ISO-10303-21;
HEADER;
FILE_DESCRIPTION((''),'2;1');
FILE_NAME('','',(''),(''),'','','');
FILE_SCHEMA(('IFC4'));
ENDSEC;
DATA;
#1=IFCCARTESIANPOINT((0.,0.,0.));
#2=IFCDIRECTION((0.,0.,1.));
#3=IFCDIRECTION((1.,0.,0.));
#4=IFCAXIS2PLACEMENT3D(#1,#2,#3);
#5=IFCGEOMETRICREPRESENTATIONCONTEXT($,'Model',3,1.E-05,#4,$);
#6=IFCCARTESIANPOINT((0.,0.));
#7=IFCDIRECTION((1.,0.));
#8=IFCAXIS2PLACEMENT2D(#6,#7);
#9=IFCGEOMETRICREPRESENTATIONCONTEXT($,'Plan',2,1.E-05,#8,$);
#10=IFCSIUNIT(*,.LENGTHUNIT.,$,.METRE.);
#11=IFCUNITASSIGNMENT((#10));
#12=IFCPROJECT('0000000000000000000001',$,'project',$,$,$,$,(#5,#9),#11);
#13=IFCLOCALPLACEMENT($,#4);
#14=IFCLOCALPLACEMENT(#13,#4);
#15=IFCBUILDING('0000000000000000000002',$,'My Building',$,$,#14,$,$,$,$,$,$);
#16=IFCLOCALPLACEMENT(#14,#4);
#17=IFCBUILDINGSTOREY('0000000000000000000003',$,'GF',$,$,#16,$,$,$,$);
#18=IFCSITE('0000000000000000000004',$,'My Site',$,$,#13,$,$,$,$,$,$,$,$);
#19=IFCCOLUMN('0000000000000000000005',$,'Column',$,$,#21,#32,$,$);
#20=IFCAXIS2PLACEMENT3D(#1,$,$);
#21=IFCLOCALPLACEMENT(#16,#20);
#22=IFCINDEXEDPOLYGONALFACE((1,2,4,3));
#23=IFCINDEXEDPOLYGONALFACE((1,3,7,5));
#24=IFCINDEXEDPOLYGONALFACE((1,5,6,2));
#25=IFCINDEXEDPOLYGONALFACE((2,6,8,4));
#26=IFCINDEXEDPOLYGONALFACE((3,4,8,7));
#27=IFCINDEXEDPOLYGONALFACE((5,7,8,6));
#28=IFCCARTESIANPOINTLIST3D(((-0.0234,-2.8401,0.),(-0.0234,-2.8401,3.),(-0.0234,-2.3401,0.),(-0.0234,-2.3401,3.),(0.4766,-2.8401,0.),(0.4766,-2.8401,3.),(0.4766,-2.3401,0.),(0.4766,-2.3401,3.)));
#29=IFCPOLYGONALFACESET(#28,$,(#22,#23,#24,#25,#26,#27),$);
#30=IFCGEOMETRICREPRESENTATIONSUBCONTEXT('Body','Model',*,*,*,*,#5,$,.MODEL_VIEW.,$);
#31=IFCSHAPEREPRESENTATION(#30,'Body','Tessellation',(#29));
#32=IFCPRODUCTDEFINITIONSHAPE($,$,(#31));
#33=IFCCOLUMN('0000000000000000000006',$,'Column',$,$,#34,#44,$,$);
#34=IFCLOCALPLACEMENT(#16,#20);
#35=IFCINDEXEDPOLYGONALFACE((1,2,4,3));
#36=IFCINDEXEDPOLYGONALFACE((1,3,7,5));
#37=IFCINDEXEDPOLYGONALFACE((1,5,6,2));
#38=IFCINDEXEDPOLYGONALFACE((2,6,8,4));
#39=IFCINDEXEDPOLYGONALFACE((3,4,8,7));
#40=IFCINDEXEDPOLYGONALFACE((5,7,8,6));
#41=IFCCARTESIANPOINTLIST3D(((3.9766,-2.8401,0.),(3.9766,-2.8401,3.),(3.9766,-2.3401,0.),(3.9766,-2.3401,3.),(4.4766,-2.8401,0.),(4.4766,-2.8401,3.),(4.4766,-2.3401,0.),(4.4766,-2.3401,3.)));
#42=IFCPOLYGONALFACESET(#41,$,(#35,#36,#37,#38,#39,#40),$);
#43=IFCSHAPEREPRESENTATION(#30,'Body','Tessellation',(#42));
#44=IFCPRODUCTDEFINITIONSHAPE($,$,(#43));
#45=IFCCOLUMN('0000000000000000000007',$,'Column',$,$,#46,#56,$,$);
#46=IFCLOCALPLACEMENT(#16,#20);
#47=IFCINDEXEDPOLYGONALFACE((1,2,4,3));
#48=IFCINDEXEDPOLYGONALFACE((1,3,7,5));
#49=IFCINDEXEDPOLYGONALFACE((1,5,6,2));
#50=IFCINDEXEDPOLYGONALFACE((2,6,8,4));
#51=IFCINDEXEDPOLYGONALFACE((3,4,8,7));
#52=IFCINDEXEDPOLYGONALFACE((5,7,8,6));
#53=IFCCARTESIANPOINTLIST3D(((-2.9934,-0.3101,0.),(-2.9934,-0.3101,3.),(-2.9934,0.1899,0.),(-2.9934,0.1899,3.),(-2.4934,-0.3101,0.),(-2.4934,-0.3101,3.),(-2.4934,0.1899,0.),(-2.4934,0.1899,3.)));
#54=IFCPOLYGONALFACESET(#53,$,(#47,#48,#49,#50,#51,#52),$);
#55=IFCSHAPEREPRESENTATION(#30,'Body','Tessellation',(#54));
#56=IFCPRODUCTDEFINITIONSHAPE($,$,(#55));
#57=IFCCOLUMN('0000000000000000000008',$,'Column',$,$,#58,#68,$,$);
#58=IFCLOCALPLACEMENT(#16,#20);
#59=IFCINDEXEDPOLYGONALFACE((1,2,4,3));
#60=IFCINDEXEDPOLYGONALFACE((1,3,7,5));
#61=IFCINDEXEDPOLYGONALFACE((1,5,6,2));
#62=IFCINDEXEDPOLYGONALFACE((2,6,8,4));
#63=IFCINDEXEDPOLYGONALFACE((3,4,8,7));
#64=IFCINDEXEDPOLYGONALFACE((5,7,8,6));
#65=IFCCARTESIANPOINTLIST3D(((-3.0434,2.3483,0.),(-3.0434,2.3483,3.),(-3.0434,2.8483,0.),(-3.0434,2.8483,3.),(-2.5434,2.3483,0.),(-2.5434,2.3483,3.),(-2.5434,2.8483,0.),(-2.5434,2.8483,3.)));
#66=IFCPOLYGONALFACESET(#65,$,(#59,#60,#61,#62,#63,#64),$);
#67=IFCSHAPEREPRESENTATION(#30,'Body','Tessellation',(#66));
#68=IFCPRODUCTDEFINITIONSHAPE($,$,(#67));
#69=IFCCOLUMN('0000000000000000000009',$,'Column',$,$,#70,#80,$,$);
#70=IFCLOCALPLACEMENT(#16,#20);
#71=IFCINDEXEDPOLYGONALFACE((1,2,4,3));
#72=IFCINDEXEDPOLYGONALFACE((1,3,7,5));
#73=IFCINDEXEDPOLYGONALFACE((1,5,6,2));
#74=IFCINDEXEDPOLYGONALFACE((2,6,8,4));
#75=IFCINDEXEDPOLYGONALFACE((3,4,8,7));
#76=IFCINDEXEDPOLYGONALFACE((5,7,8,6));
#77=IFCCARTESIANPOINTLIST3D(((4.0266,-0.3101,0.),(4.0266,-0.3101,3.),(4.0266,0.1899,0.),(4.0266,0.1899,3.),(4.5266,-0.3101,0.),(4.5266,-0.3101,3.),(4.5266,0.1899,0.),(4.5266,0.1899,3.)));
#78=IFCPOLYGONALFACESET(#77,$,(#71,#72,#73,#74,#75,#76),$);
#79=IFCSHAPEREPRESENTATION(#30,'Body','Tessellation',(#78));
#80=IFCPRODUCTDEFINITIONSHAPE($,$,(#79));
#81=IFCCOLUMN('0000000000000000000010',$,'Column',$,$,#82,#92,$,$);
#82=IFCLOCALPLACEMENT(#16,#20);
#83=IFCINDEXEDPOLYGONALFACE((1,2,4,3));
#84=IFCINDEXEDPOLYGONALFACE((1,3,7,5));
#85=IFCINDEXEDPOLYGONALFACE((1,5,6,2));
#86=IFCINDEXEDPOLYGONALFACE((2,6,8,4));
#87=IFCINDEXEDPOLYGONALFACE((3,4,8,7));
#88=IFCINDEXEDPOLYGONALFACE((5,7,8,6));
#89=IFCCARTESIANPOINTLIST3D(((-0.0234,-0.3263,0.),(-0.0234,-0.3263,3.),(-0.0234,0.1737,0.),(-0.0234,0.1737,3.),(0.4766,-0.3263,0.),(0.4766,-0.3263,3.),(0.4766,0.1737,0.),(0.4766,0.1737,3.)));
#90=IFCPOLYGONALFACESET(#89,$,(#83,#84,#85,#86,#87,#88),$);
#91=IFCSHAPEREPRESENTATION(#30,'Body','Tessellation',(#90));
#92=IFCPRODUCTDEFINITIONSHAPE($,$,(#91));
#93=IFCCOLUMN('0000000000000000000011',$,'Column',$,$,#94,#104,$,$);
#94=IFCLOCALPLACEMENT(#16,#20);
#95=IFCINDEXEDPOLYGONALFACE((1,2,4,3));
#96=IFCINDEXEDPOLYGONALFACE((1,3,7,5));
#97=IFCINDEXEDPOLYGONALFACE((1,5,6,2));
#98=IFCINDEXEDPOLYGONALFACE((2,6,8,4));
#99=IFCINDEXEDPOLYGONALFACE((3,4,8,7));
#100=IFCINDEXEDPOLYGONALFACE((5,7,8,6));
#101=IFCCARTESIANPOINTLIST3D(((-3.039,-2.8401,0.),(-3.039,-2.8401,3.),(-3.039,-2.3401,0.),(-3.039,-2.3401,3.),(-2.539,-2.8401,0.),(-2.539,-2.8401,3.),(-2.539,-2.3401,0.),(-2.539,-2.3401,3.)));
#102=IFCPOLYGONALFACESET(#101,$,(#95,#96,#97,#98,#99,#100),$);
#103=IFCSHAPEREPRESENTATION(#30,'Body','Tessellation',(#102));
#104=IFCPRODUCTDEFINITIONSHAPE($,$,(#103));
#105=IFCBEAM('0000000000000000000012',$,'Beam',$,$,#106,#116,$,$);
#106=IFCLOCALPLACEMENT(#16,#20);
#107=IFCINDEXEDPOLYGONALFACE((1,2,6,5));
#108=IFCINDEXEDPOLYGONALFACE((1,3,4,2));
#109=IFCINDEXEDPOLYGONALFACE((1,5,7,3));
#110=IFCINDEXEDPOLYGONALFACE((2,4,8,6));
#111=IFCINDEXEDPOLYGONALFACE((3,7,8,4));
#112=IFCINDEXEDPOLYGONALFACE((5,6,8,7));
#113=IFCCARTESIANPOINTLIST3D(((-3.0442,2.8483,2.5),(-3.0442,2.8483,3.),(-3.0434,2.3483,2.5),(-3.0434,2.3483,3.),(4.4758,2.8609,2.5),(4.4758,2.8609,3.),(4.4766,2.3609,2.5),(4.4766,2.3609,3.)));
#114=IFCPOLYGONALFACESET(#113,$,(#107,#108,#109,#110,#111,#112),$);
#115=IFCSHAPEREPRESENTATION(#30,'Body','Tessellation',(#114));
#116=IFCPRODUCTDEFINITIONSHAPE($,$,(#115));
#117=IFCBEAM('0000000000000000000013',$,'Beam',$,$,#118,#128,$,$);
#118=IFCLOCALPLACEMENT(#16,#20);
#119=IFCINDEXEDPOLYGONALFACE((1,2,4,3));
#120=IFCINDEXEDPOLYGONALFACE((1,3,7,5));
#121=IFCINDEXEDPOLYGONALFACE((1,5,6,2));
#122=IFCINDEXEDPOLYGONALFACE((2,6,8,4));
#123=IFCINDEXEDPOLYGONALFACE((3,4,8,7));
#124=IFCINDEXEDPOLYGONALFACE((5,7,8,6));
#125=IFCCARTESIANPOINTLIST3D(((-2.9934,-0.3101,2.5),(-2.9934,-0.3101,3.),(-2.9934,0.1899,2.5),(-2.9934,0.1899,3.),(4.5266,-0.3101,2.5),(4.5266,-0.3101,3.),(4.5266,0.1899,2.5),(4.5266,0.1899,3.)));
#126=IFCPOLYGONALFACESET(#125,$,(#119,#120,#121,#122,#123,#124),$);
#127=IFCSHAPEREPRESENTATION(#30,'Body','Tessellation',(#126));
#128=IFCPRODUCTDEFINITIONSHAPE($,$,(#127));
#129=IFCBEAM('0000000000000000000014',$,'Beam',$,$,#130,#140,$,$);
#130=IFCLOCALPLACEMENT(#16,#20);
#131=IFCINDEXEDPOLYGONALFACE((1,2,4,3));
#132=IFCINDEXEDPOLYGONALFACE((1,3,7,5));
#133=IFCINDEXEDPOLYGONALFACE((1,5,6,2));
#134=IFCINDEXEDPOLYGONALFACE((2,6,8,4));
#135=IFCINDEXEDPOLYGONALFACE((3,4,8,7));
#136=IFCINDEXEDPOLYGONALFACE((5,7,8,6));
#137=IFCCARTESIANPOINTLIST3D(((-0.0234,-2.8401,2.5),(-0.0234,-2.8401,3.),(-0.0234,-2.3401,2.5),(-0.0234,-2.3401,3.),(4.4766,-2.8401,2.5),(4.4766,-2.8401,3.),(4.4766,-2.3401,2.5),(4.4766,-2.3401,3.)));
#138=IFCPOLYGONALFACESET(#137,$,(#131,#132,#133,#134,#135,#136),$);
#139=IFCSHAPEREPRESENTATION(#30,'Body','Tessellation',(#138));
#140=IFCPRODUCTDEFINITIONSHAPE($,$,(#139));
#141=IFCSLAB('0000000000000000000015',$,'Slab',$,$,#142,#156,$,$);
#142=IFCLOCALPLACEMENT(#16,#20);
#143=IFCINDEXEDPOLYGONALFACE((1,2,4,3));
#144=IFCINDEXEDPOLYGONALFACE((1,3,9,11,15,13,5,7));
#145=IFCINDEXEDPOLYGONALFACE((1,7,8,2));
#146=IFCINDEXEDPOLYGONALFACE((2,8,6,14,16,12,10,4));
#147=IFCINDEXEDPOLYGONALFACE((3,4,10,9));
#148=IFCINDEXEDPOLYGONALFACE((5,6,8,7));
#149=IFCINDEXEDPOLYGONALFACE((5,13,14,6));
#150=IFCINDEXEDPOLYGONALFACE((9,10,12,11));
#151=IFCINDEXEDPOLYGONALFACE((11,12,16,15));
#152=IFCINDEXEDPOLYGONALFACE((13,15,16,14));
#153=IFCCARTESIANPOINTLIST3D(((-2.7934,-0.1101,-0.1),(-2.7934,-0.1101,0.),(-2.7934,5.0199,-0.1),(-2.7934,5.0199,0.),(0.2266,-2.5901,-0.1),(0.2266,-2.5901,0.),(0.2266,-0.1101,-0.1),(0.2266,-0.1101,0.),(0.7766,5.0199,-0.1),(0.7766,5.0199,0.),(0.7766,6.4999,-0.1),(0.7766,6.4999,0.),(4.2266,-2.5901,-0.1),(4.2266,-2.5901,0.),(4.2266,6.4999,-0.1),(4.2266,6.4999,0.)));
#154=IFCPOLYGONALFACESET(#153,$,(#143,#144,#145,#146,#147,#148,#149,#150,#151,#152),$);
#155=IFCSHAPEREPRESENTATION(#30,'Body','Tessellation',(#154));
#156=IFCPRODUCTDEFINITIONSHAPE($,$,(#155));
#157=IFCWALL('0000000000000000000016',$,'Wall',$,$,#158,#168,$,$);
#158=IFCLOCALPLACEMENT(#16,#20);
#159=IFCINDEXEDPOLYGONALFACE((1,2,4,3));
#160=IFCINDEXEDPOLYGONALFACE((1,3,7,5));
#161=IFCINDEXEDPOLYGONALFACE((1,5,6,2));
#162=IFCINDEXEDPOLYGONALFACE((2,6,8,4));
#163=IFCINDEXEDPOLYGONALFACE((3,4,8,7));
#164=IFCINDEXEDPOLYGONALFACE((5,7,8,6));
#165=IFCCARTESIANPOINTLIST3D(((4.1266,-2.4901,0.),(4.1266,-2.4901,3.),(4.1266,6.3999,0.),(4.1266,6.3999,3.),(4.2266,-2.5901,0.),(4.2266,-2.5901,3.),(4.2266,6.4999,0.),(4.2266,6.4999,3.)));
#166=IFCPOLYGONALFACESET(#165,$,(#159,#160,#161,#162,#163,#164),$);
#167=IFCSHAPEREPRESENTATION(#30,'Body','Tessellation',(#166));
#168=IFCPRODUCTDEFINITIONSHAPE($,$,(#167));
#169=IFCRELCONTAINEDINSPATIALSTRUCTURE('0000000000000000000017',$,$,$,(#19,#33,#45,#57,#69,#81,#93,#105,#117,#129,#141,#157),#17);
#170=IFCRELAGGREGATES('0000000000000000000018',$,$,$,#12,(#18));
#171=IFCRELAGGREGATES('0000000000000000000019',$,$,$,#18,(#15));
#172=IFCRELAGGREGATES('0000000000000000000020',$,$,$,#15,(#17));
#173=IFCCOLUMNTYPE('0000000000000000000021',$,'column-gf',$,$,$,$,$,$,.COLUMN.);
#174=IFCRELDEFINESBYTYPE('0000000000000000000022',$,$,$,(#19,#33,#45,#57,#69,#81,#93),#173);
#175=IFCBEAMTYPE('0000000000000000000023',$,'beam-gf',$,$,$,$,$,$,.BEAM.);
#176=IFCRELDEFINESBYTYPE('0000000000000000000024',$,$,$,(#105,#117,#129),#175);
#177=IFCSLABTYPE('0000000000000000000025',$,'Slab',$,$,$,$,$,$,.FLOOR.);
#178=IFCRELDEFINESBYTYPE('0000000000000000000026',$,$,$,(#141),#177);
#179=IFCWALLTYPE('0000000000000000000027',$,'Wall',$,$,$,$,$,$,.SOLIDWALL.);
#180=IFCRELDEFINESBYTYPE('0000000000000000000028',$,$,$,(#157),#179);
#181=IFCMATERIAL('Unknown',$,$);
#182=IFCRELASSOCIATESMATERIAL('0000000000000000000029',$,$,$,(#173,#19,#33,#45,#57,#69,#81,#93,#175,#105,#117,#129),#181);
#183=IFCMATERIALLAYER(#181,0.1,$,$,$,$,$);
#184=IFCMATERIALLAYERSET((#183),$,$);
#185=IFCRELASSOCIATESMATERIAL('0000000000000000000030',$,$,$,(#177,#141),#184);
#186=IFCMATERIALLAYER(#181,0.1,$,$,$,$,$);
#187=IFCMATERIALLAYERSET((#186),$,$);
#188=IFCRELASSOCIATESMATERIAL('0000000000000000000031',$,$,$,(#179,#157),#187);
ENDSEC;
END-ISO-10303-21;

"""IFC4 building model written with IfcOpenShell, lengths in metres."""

from ifc_helpers import new_model, si_unit, frame, origin_with_axes, origin_2d_with_axis, place, context, subcontext, project, spatial, line, indexed_curve, rectangle, outline, extrude, material, layer, layer_set, layer_usage, material_profile, profile_set, profile_usage, type_object, element, save


model = new_model("IFC4")

# Units and contexts
model_context = context("Model", 3, precision=1e-05, world=origin_with_axes())
plan_context = context("Plan", 2, precision=1e-05, world=origin_2d_with_axis())
body_context_1 = subcontext(model_context, "Body", "Model", "MODEL_VIEW")
ifc_project = project(units=[si_unit("LENGTHUNIT", "METRE")], contexts=[model_context, plan_context])

# Site, building, storey
site_placement = place(None, origin_with_axes())
site = spatial("IfcSite", under=ifc_project, at=site_placement, Name="My Site")
building_placement = place(site_placement, origin_with_axes())
building = spatial("IfcBuilding", under=site, at=building_placement, Name="My Building")
storey_placement = place(building_placement, origin_with_axes())
storey = spatial("IfcBuildingStorey", under=building, at=storey_placement, Name="GF")

# Columns
ifc_material = material(Name="Unknown")
ifc_material_profile_1 = material_profile(ifc_material, rectangle(XDim=0.5, YDim=0.5))
ifc_profile_set_1 = profile_set([ifc_material_profile_1])
ifc_profile_usage_1 = profile_usage(ifc_profile_set_1, cardinal=5)
column_type = type_object("IfcColumnType", Name="column-gf", PredefinedType="COLUMN", material=ifc_profile_set_1)
column_1_placement = place(storey_placement, frame((0.2266, -2.5901, 0.0), z_axis=(0.0, 0.0, 1.0), x_axis=(1.0, 0.0, 0.0)))
element("IfcColumn", 1, at=column_1_placement, inside=storey, type_object=column_type, material=ifc_profile_usage_1, Name="Column", context=body_context_1, shape_type="SweptSolid", body=[
    extrude(rectangle(XDim=0.5, YDim=0.5), origin_with_axes(), (0.0, 0.0, 1.0), 3.0),
])
ifc_profile_usage_2 = profile_usage(ifc_profile_set_1, cardinal=5)
column_2_placement = place(storey_placement, frame((4.2266, -2.5901, 0.0), z_axis=(0.0, 0.0, 1.0), x_axis=(1.0, 0.0, 0.0)))
element("IfcColumn", 2, at=column_2_placement, inside=storey, type_object=column_type, material=ifc_profile_usage_2, Name="Column", context=body_context_1, shape_type="SweptSolid", body=[
    extrude(rectangle(XDim=0.5, YDim=0.5), origin_with_axes(), (0.0, 0.0, 1.0), 3.0),
])
ifc_profile_usage_3 = profile_usage(ifc_profile_set_1, cardinal=5)
column_3_placement = place(storey_placement, frame((-2.7434, -0.0601, 0.0), z_axis=(0.0, 0.0, 1.0), x_axis=(1.0, 0.0, 0.0)))
element("IfcColumn", 3, at=column_3_placement, inside=storey, type_object=column_type, material=ifc_profile_usage_3, Name="Column", context=body_context_1, shape_type="SweptSolid", body=[
    extrude(rectangle(XDim=0.5, YDim=0.5), origin_with_axes(), (0.0, 0.0, 1.0), 3.0),
])
ifc_profile_usage_4 = profile_usage(ifc_profile_set_1, cardinal=5)
column_4_placement = place(storey_placement, frame((-2.7934, 2.5983, 0.0), z_axis=(0.0, 0.0, 1.0), x_axis=(1.0, 0.0, 0.0)))
element("IfcColumn", 4, at=column_4_placement, inside=storey, type_object=column_type, material=ifc_profile_usage_4, Name="Column", context=body_context_1, shape_type="SweptSolid", body=[
    extrude(rectangle(XDim=0.5, YDim=0.5), origin_with_axes(), (0.0, 0.0, 1.0), 3.0),
])
ifc_profile_usage_5 = profile_usage(ifc_profile_set_1, cardinal=5)
column_5_placement = place(storey_placement, frame((4.2766, -0.0601, 0.0), z_axis=(0.0, 0.0, 1.0), x_axis=(1.0, 0.0, 0.0)))
element("IfcColumn", 5, at=column_5_placement, inside=storey, type_object=column_type, material=ifc_profile_usage_5, Name="Column", context=body_context_1, shape_type="SweptSolid", body=[
    extrude(rectangle(XDim=0.5, YDim=0.5), origin_with_axes(), (0.0, 0.0, 1.0), 3.0),
])
ifc_profile_usage_6 = profile_usage(ifc_profile_set_1, cardinal=5)
column_6_placement = place(storey_placement, frame((0.2266, -0.0763, 0.0), z_axis=(0.0, 0.0, 1.0), x_axis=(1.0, 0.0, 0.0)))
element("IfcColumn", 6, at=column_6_placement, inside=storey, type_object=column_type, material=ifc_profile_usage_6, Name="Column", context=body_context_1, shape_type="SweptSolid", body=[
    extrude(rectangle(XDim=0.5, YDim=0.5), origin_with_axes(), (0.0, 0.0, 1.0), 3.0),
])
ifc_profile_usage_7 = profile_usage(ifc_profile_set_1, cardinal=5)
column_7_placement = place(storey_placement, frame((-2.789, -2.5901, 0.0), z_axis=(0.0, 0.0, 1.0), x_axis=(1.0, 0.0, 0.0)))
element("IfcColumn", 7, at=column_7_placement, inside=storey, type_object=column_type, material=ifc_profile_usage_7, Name="Column", context=body_context_1, shape_type="SweptSolid", body=[
    extrude(rectangle(XDim=0.5, YDim=0.5), origin_with_axes(), (0.0, 0.0, 1.0), 3.0),
])

# Beams
ifc_material_profile_2 = material_profile(ifc_material, rectangle(XDim=0.5, YDim=0.5))
ifc_profile_set_2 = profile_set([ifc_material_profile_2])
ifc_profile_usage_8 = profile_usage(ifc_profile_set_2, cardinal=7)
beam_type = type_object("IfcBeamType", Name="beam-gf", PredefinedType="BEAM", material=ifc_profile_set_2)
beam_1_placement = place(storey_placement, frame((4.4766, 2.3609, 3.0), z_axis=(-0.999999, -0.001682, 0.0), x_axis=(0.001682, -0.999999, 0.0)))
element("IfcBeam", 8, at=beam_1_placement, inside=storey, type_object=beam_type, material=ifc_profile_usage_8, Name="Beam", context=body_context_1, shape_type="SweptSolid", body=[
    extrude(rectangle(XDim=0.5, YDim=0.5), frame((-0.25, -0.25, 0.0), z_axis=(0.0, 0.0, 1.0), x_axis=(1.0, 0.0, 0.0)), (0.0, 0.0, 1.0), 7.52),
])
ifc_profile_usage_9 = profile_usage(ifc_profile_set_2, cardinal=7)
beam_2_placement = place(storey_placement, frame((4.5266, -0.3101, 3.0), z_axis=(-1.0, 0.0, 0.0), x_axis=(0.0, -1.0, 0.0)))
element("IfcBeam", 9, at=beam_2_placement, inside=storey, type_object=beam_type, material=ifc_profile_usage_9, Name="Beam", context=body_context_1, shape_type="SweptSolid", body=[
    extrude(rectangle(XDim=0.5, YDim=0.5), frame((-0.25, -0.25, 0.0), z_axis=(0.0, 0.0, 1.0), x_axis=(1.0, 0.0, 0.0)), (0.0, 0.0, 1.0), 7.52),
])
ifc_profile_usage_10 = profile_usage(ifc_profile_set_2, cardinal=7)
beam_3_placement = place(storey_placement, frame((4.4766, -2.8401, 3.0), z_axis=(-1.0, -0.000001, 0.000001), x_axis=(0.000001, -1.0, 0.0)))
element("IfcBeam", 10, at=beam_3_placement, inside=storey, type_object=beam_type, material=ifc_profile_usage_10, Name="Beam", context=body_context_1, shape_type="SweptSolid", body=[
    extrude(rectangle(XDim=0.5, YDim=0.5), frame((-0.25, -0.25, 0.0), z_axis=(0.0, 0.0, 1.0), x_axis=(1.0, 0.0, 0.0)), (0.0, 0.0, 1.0), 4.5),
])

# Slab
ifc_layer_1 = layer(ifc_material, 0.1)
ifc_layer_set_1 = layer_set([ifc_layer_1])
ifc_layer_usage_1 = layer_usage(ifc_layer_set_1, "AXIS3", "POSITIVE", -0.1)
slab_type_1 = type_object("IfcSlabType", Name="Slab", PredefinedType="FLOOR", material=ifc_layer_set_1)
slab_1_placement = place(storey_placement, frame((4.2266, -2.5901, 0.0), z_axis=(0.0, 0.0, 1.0), x_axis=(1.0, 0.0, 0.0)))
element("IfcSlab", 11, at=slab_1_placement, inside=storey, type_object=slab_type_1, material=ifc_layer_usage_1, Name="Slab", context=body_context_1, shape_type="SweptSolid", body=[
    extrude(outline(indexed_curve([(0.0, 0.0), (0.0, 9.09), (-3.45, 9.09), (-3.45, 7.61), (-7.02, 7.61), (-7.02, 2.48), (-4.0, 2.48), (-4.0, 0.0), (0.0, 0.0)])), frame((0.0, 0.0, -0.1), z_axis=(0.0, 0.0, 1.0), x_axis=(1.0, 0.0, 0.0)), (0.0, 0.0, 1.0), 0.1),
])

# Shared definitions
ifc_layer_2 = layer(ifc_material, 0.1)
ifc_layer_set_2 = layer_set([ifc_layer_2])
wall_type = type_object("IfcWallType", Name="Wall", PredefinedType="SOLIDWALL", material=ifc_layer_set_2)

# Wall
ifc_layer_usage_2 = layer_usage(ifc_layer_set_2, "AXIS2", "POSITIVE", 0.0)
wall_1_placement = place(storey_placement, frame((4.2266, -2.5901, 0.0), z_axis=(0.0, 0.0, 1.0), x_axis=(0.0, 1.0, 0.0)))
element("IfcWall", 12, at=wall_1_placement, inside=storey, type_object=wall_type, material=ifc_layer_usage_2, Name="Wall", context=body_context_1, shape_type="SweptSolid", body=[
    extrude(outline(indexed_curve([(0.0, 0.0), (0.1, 0.1), (8.99, 0.1), (9.09, 0.0)], segments=[line(1, 2, 3, 4, 1)])), origin_with_axes(), (0.0, 0.0, 1.0), 3.0),
])

save(model, "model.ifc")
